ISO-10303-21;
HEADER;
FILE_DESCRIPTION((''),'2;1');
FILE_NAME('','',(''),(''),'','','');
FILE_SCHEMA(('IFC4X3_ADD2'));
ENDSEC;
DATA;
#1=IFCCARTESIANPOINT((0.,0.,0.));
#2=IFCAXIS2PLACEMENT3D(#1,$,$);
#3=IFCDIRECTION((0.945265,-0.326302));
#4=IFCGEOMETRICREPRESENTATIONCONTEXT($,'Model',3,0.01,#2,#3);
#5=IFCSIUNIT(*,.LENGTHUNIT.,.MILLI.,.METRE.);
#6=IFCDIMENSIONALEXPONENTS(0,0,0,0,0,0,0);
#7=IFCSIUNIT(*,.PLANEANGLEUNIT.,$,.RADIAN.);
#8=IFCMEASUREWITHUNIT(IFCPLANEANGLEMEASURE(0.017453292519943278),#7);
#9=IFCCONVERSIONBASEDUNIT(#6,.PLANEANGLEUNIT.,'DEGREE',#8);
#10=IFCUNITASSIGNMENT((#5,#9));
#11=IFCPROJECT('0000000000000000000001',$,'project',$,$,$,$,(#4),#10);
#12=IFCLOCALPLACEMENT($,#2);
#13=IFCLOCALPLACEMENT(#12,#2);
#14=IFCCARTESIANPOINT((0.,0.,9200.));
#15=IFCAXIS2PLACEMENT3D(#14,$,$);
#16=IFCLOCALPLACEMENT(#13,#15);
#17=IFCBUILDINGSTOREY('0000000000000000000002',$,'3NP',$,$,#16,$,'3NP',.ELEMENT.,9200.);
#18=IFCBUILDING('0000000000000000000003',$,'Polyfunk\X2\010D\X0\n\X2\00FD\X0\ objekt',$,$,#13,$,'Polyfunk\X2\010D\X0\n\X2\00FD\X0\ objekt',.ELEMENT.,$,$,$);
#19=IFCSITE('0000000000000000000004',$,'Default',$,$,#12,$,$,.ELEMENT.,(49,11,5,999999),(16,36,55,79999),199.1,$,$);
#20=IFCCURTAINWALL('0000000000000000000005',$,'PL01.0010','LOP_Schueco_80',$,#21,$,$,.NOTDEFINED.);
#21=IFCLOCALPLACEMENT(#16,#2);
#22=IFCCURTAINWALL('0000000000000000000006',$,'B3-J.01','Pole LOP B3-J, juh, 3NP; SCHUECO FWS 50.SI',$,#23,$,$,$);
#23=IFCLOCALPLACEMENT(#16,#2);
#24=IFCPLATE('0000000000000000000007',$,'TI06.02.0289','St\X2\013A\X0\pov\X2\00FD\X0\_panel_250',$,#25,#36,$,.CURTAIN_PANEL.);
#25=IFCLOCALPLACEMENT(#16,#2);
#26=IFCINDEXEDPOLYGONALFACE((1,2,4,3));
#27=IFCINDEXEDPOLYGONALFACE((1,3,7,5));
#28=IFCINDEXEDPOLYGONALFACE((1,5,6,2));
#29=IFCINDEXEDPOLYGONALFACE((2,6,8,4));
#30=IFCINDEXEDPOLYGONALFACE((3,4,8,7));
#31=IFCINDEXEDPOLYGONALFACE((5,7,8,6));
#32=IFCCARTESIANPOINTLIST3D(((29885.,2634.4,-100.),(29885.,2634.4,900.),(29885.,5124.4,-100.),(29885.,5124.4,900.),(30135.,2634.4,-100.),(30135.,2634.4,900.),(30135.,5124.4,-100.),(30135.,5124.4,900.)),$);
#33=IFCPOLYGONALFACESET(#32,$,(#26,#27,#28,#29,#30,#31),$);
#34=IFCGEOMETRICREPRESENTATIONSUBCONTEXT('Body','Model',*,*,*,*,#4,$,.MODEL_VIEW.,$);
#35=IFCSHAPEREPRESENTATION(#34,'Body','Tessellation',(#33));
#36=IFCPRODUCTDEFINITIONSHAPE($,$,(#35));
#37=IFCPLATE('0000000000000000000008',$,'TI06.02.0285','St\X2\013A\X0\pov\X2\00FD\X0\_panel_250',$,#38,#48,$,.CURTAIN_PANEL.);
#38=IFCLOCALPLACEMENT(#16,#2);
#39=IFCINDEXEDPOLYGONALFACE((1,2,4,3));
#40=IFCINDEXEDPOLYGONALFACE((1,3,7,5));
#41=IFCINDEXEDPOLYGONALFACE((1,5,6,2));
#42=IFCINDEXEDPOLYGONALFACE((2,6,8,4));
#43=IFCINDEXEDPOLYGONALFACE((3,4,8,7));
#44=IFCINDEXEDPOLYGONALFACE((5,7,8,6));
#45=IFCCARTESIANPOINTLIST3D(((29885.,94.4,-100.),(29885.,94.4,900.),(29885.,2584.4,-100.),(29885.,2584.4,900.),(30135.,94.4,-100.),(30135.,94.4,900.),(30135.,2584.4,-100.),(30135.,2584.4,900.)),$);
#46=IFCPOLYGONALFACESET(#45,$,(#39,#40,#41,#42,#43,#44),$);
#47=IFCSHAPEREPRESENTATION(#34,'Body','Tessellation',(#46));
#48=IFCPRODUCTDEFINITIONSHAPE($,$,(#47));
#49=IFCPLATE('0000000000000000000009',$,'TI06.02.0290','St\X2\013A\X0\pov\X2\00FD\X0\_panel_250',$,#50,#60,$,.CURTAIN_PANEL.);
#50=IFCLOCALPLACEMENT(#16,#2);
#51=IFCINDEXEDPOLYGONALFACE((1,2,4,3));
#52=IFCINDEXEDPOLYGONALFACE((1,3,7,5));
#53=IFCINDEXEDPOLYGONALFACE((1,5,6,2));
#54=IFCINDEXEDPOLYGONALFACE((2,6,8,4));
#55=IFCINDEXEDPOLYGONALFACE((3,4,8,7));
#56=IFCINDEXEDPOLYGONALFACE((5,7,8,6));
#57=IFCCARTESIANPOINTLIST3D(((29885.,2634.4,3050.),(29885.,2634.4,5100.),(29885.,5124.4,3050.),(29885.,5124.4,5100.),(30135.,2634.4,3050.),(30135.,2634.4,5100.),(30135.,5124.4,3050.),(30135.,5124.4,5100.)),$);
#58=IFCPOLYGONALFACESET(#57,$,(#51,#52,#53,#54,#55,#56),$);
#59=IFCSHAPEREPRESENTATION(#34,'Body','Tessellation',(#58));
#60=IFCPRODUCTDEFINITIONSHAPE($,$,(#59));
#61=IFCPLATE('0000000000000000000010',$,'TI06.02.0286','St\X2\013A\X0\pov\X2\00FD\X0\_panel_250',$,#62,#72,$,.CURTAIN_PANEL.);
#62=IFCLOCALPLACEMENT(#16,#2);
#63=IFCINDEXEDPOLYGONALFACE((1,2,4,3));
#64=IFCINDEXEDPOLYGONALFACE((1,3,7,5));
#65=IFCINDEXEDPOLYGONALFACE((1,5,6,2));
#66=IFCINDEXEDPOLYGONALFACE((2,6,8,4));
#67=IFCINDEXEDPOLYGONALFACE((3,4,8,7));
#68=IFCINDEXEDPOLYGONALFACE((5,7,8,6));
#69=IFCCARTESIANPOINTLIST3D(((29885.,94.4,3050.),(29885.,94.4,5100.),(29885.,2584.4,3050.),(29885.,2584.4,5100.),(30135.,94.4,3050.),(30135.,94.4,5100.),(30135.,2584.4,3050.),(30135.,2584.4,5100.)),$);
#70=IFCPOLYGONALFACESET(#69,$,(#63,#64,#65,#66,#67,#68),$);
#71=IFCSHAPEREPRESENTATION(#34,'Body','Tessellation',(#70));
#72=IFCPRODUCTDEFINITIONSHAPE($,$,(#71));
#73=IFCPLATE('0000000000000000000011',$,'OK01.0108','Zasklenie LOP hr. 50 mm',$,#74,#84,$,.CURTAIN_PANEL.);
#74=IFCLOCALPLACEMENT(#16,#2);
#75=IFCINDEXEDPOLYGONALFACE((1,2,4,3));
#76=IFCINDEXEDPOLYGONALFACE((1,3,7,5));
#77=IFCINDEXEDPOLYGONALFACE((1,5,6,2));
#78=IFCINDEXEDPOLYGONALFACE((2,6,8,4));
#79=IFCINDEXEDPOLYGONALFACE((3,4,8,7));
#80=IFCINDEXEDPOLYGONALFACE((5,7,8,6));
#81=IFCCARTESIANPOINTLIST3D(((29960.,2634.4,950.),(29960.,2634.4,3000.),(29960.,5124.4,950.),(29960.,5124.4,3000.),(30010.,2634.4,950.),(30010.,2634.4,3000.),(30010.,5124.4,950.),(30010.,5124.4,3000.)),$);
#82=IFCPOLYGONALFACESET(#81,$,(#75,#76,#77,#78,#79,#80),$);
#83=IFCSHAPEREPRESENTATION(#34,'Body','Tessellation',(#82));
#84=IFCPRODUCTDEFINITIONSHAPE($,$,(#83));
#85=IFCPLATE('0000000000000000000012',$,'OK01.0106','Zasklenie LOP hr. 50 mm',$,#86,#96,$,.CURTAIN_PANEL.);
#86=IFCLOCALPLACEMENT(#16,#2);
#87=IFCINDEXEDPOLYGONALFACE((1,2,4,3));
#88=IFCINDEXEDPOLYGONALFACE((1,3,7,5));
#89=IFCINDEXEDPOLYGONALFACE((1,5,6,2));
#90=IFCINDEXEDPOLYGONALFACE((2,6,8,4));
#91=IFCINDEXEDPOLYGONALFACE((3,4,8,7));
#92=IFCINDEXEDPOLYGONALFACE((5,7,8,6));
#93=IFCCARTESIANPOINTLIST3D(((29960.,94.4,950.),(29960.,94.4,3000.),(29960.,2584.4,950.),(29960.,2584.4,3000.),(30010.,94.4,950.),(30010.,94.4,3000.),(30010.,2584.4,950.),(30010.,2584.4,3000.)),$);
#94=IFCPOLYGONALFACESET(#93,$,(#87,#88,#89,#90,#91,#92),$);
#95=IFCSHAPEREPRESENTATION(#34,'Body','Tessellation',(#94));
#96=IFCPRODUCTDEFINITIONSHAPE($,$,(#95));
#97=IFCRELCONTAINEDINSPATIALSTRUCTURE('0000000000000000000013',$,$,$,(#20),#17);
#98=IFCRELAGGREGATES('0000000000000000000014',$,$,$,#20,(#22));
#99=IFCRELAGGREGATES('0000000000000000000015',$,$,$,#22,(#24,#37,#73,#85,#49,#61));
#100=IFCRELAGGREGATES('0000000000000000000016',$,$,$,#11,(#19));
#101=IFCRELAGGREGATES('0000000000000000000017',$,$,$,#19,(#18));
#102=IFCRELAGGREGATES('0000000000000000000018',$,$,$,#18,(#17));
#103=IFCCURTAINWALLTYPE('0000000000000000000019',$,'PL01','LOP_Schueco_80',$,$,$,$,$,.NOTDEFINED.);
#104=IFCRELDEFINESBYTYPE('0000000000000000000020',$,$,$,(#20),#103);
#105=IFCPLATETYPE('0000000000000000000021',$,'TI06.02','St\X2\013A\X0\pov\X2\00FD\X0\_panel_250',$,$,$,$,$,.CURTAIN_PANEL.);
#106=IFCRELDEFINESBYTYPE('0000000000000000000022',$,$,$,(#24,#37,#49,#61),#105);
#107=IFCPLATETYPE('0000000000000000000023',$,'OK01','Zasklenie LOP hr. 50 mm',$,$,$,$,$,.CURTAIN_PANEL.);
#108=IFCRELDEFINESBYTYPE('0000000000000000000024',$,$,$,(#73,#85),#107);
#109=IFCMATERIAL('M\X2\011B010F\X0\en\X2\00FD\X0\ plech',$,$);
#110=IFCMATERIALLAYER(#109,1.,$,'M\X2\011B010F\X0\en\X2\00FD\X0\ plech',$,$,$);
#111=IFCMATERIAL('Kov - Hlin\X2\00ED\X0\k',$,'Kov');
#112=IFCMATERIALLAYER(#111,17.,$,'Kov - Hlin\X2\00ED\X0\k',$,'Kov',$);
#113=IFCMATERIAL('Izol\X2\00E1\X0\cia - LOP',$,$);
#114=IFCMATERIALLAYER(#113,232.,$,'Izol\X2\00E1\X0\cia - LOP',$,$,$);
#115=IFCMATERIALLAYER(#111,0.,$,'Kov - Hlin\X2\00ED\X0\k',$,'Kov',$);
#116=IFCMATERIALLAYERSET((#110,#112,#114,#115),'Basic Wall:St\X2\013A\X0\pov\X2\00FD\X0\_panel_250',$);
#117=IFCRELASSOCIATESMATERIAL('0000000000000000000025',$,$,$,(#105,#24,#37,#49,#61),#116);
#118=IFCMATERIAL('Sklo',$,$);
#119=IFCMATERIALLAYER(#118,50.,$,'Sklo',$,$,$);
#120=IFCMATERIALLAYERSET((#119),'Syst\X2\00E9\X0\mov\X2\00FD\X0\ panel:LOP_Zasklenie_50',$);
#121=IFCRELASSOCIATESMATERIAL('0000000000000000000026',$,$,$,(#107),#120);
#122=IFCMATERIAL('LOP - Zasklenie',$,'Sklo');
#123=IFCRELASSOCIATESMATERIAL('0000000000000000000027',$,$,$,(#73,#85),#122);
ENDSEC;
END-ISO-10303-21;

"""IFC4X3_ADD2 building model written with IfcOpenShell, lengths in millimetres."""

from ifc_helpers import new_model, entity, si_unit, converted_unit, direction, frame, frame_2d, origin, origin_2d_with_axis, place, context, subcontext, project, spatial, rectangle, extrude, source, transform, mapped, material, layer, layer_set, layer_usage, type_object, type_shapes, element, aggregate, save


model = new_model("IFC4X3_ADD2")

# Units and contexts
model_context = context("Model", 3, precision=0.01, world=origin(), true_north=direction((0.945265, -0.326302)))
body_context = subcontext(model_context, "Body", "Model", "MODEL_VIEW")
ifc_project = project(units=[si_unit("LENGTHUNIT", "METRE", prefix="MILLI"), converted_unit("PLANEANGLEUNIT", "DEGREE", entity("IfcPlaneAngleMeasure", 0.017453292519943278), si_unit("PLANEANGLEUNIT", "RADIAN"), dimensions=[0, 0, 0, 0, 0, 0, 0])], contexts=[model_context])

# Site, building, storey
site_placement = place(None, origin())
site = spatial("IfcSite", under=ifc_project, at=site_placement, Name="Default", CompositionType="ELEMENT", RefLatitude=(49, 11, 5, 999999), RefLongitude=(16, 36, 55, 79999), RefElevation=199.1)
building_placement = place(site_placement, origin())
building = spatial("IfcBuilding", under=site, at=building_placement, Name="Polyfunkčný objekt", LongName="Polyfunkčný objekt", CompositionType="ELEMENT")
storey_placement = place(building_placement, frame((0.0, 0.0, 9200.0)))
storey = spatial("IfcBuildingStorey", under=building, at=storey_placement, Name="3NP", LongName="3NP", CompositionType="ELEMENT", Elevation=9200.0)

# Shared definitions
curtain_wall_type = type_object("IfcCurtainWallType", Name="PL01", Description="LOP_Schueco_80", PredefinedType="NOTDEFINED")

# Curtain walls
curtain_wall_1_placement = place(storey_placement, frame((0.0, 0.0, -9200.0)))
curtain_wall_1 = element("IfcCurtainWall", 1, at=curtain_wall_1_placement, inside=storey, type_object=curtain_wall_type, Name="PL01.0010", Description="LOP_Schueco_80", PredefinedType="NOTDEFINED")
curtain_wall_2 = element("IfcCurtainWall", 2, Name="B3-J.01", Description="Pole LOP B3-J, juh, 3NP; SCHUECO FWS 50.SI")
aggregate(curtain_wall_1, [curtain_wall_2])

# Plates
ifc_material_1 = material(Name="Měďený plech")
ifc_layer_1 = layer(ifc_material_1, 1.0, Name="Měďený plech")
ifc_material_2 = material(Name="Kov - Hliník", Category="Kov")
ifc_layer_2 = layer(ifc_material_2, 17.0, Name="Kov - Hliník", Category="Kov")
ifc_material_3 = material(Name="Izolácia - LOP")
ifc_layer_3 = layer(ifc_material_3, 232.0, Name="Izolácia - LOP")
ifc_layer_4 = layer(ifc_material_2, 0.0, Name="Kov - Hliník", Category="Kov")
ifc_layer_set_1 = layer_set([ifc_layer_1, ifc_layer_2, ifc_layer_3, ifc_layer_4], Name="Basic Wall:Stĺpový_panel_250")
ifc_layer_usage_1 = layer_usage(ifc_layer_set_1, "AXIS2", "POSITIVE", -125.0)
plate_type_1 = type_object("IfcPlateType", Name="TI06.02", Description="Stĺpový_panel_250", PredefinedType="CURTAIN_PANEL", material=ifc_layer_set_1)
plate_1_placement = place(storey_placement, frame((30010.0, 5124.4, -100.0), z_axis=(0.0, 0.0, 1.0), x_axis=(0.0, -1.0, 0.0)))
plate_1 = element("IfcPlate", 3, at=plate_1_placement, type_object=plate_type_1, material=ifc_layer_usage_1, Name="TI06.02.0289", Description="Stĺpový_panel_250", PredefinedType="CURTAIN_PANEL", context=body_context, shape_type="SweptSolid", body=[
    extrude(rectangle(XDim=250.0, YDim=2490.0, at=frame_2d((0.0, 0.0), x_axis=(1.0, 0.0))), frame((1245.0, 0.0, 0.0), z_axis=(0.0, 0.0, 1.0), x_axis=(0.0, 1.0, 0.0)), (0.0, 0.0, 1.0), 1000.0),
])
ifc_layer_usage_2 = layer_usage(ifc_layer_set_1, "AXIS2", "POSITIVE", -125.0)
plate_2_placement = place(storey_placement, frame((30010.0, 2584.4, -100.0), z_axis=(0.0, 0.0, 1.0), x_axis=(0.0, -1.0, 0.0)))
plate_2 = element("IfcPlate", 4, at=plate_2_placement, type_object=plate_type_1, material=ifc_layer_usage_2, Name="TI06.02.0285", Description="Stĺpový_panel_250", PredefinedType="CURTAIN_PANEL", context=body_context, shape_type="SweptSolid", body=[
    extrude(rectangle(XDim=250.0, YDim=2490.0, at=frame_2d((0.0, 0.0), x_axis=(1.0, 0.0))), frame((1245.0, 0.0, 0.0), z_axis=(0.0, 0.0, 1.0), x_axis=(0.0, 1.0, 0.0)), (0.0, 0.0, 1.0), 1000.0),
])
ifc_layer_usage_3 = layer_usage(ifc_layer_set_1, "AXIS2", "POSITIVE", -125.0)
plate_3_placement = place(storey_placement, frame((30010.0, 5124.4, 3050.0), z_axis=(0.0, 0.0, 1.0), x_axis=(0.0, -1.0, 0.0)))
plate_3 = element("IfcPlate", 5, at=plate_3_placement, type_object=plate_type_1, material=ifc_layer_usage_3, Name="TI06.02.0290", Description="Stĺpový_panel_250", PredefinedType="CURTAIN_PANEL", context=body_context, shape_type="SweptSolid", body=[
    extrude(rectangle(XDim=250.0, YDim=2490.0, at=frame_2d((0.0, 0.0), x_axis=(1.0, 0.0))), frame((1245.0, 0.0, 0.0), z_axis=(0.0, 0.0, 1.0), x_axis=(0.0, 1.0, 0.0)), (0.0, 0.0, 1.0), 2050.0),
])
ifc_layer_usage_4 = layer_usage(ifc_layer_set_1, "AXIS2", "POSITIVE", -125.0)
plate_4_placement = place(storey_placement, frame((30010.0, 2584.4, 3050.0), z_axis=(0.0, 0.0, 1.0), x_axis=(0.0, -1.0, 0.0)))
plate_4 = element("IfcPlate", 6, at=plate_4_placement, type_object=plate_type_1, material=ifc_layer_usage_4, Name="TI06.02.0286", Description="Stĺpový_panel_250", PredefinedType="CURTAIN_PANEL", context=body_context, shape_type="SweptSolid", body=[
    extrude(rectangle(XDim=250.0, YDim=2490.0, at=frame_2d((0.0, 0.0), x_axis=(1.0, 0.0))), frame((1245.0, 0.0, 0.0), z_axis=(0.0, 0.0, 1.0), x_axis=(0.0, 1.0, 0.0)), (0.0, 0.0, 1.0), 2050.0),
])
ifc_material_4 = material(Name="LOP - Zasklenie", Category="Sklo")
ifc_material_5 = material(Name="Sklo")
ifc_layer_5 = layer(ifc_material_5, 50.0, Name="Sklo")
ifc_layer_set_2 = layer_set([ifc_layer_5], Name="Systémový panel:LOP_Zasklenie_50")
plate_type_2 = type_object("IfcPlateType", Name="OK01", Description="Zasklenie LOP hr. 50 mm", PredefinedType="CURTAIN_PANEL", material=ifc_layer_set_2)
shared_shape_1 = source(origin(), body_context, "Body", "SweptSolid", [
    extrude(rectangle(XDim=50.0, YDim=2490.0, at=origin_2d_with_axis()), frame((0.0, -25.0, 0.0), z_axis=(0.0, 0.0, 1.0), x_axis=(0.0, 1.0, 0.0)), (0.0, 0.0, 1.0), 2050.0),
])
type_shapes(plate_type_2, [shared_shape_1])
plate_5_placement = place(curtain_wall_1_placement, frame((30010.0, 3879.4, 10150.0), z_axis=(0.0, 0.0, 1.0), x_axis=(0.0, -1.0, 0.0)))
plate_5 = element("IfcPlate", 7, at=plate_5_placement, type_object=plate_type_2, material=ifc_material_4, Name="OK01.0108", Description="Zasklenie LOP hr. 50 mm", PredefinedType="CURTAIN_PANEL", context=body_context, shape_type="MappedRepresentation", body=[
    mapped(shared_shape_1, transform((0.0, 0.0, 0.0), scale=1.0)),
])
plate_6_placement = place(curtain_wall_1_placement, frame((30010.0, 1339.4, 10150.0), z_axis=(0.0, 0.0, 1.0), x_axis=(0.0, -1.0, 0.0)))
plate_6 = element("IfcPlate", 8, at=plate_6_placement, type_object=plate_type_2, material=ifc_material_4, Name="OK01.0106", Description="Zasklenie LOP hr. 50 mm", PredefinedType="CURTAIN_PANEL", context=body_context, shape_type="MappedRepresentation", body=[
    mapped(shared_shape_1, transform((0.0, 0.0, 0.0), scale=1.0)),
])
aggregate(curtain_wall_2, [plate_1, plate_2, plate_5, plate_6, plate_3, plate_4])

save(model, "model.ifc")
